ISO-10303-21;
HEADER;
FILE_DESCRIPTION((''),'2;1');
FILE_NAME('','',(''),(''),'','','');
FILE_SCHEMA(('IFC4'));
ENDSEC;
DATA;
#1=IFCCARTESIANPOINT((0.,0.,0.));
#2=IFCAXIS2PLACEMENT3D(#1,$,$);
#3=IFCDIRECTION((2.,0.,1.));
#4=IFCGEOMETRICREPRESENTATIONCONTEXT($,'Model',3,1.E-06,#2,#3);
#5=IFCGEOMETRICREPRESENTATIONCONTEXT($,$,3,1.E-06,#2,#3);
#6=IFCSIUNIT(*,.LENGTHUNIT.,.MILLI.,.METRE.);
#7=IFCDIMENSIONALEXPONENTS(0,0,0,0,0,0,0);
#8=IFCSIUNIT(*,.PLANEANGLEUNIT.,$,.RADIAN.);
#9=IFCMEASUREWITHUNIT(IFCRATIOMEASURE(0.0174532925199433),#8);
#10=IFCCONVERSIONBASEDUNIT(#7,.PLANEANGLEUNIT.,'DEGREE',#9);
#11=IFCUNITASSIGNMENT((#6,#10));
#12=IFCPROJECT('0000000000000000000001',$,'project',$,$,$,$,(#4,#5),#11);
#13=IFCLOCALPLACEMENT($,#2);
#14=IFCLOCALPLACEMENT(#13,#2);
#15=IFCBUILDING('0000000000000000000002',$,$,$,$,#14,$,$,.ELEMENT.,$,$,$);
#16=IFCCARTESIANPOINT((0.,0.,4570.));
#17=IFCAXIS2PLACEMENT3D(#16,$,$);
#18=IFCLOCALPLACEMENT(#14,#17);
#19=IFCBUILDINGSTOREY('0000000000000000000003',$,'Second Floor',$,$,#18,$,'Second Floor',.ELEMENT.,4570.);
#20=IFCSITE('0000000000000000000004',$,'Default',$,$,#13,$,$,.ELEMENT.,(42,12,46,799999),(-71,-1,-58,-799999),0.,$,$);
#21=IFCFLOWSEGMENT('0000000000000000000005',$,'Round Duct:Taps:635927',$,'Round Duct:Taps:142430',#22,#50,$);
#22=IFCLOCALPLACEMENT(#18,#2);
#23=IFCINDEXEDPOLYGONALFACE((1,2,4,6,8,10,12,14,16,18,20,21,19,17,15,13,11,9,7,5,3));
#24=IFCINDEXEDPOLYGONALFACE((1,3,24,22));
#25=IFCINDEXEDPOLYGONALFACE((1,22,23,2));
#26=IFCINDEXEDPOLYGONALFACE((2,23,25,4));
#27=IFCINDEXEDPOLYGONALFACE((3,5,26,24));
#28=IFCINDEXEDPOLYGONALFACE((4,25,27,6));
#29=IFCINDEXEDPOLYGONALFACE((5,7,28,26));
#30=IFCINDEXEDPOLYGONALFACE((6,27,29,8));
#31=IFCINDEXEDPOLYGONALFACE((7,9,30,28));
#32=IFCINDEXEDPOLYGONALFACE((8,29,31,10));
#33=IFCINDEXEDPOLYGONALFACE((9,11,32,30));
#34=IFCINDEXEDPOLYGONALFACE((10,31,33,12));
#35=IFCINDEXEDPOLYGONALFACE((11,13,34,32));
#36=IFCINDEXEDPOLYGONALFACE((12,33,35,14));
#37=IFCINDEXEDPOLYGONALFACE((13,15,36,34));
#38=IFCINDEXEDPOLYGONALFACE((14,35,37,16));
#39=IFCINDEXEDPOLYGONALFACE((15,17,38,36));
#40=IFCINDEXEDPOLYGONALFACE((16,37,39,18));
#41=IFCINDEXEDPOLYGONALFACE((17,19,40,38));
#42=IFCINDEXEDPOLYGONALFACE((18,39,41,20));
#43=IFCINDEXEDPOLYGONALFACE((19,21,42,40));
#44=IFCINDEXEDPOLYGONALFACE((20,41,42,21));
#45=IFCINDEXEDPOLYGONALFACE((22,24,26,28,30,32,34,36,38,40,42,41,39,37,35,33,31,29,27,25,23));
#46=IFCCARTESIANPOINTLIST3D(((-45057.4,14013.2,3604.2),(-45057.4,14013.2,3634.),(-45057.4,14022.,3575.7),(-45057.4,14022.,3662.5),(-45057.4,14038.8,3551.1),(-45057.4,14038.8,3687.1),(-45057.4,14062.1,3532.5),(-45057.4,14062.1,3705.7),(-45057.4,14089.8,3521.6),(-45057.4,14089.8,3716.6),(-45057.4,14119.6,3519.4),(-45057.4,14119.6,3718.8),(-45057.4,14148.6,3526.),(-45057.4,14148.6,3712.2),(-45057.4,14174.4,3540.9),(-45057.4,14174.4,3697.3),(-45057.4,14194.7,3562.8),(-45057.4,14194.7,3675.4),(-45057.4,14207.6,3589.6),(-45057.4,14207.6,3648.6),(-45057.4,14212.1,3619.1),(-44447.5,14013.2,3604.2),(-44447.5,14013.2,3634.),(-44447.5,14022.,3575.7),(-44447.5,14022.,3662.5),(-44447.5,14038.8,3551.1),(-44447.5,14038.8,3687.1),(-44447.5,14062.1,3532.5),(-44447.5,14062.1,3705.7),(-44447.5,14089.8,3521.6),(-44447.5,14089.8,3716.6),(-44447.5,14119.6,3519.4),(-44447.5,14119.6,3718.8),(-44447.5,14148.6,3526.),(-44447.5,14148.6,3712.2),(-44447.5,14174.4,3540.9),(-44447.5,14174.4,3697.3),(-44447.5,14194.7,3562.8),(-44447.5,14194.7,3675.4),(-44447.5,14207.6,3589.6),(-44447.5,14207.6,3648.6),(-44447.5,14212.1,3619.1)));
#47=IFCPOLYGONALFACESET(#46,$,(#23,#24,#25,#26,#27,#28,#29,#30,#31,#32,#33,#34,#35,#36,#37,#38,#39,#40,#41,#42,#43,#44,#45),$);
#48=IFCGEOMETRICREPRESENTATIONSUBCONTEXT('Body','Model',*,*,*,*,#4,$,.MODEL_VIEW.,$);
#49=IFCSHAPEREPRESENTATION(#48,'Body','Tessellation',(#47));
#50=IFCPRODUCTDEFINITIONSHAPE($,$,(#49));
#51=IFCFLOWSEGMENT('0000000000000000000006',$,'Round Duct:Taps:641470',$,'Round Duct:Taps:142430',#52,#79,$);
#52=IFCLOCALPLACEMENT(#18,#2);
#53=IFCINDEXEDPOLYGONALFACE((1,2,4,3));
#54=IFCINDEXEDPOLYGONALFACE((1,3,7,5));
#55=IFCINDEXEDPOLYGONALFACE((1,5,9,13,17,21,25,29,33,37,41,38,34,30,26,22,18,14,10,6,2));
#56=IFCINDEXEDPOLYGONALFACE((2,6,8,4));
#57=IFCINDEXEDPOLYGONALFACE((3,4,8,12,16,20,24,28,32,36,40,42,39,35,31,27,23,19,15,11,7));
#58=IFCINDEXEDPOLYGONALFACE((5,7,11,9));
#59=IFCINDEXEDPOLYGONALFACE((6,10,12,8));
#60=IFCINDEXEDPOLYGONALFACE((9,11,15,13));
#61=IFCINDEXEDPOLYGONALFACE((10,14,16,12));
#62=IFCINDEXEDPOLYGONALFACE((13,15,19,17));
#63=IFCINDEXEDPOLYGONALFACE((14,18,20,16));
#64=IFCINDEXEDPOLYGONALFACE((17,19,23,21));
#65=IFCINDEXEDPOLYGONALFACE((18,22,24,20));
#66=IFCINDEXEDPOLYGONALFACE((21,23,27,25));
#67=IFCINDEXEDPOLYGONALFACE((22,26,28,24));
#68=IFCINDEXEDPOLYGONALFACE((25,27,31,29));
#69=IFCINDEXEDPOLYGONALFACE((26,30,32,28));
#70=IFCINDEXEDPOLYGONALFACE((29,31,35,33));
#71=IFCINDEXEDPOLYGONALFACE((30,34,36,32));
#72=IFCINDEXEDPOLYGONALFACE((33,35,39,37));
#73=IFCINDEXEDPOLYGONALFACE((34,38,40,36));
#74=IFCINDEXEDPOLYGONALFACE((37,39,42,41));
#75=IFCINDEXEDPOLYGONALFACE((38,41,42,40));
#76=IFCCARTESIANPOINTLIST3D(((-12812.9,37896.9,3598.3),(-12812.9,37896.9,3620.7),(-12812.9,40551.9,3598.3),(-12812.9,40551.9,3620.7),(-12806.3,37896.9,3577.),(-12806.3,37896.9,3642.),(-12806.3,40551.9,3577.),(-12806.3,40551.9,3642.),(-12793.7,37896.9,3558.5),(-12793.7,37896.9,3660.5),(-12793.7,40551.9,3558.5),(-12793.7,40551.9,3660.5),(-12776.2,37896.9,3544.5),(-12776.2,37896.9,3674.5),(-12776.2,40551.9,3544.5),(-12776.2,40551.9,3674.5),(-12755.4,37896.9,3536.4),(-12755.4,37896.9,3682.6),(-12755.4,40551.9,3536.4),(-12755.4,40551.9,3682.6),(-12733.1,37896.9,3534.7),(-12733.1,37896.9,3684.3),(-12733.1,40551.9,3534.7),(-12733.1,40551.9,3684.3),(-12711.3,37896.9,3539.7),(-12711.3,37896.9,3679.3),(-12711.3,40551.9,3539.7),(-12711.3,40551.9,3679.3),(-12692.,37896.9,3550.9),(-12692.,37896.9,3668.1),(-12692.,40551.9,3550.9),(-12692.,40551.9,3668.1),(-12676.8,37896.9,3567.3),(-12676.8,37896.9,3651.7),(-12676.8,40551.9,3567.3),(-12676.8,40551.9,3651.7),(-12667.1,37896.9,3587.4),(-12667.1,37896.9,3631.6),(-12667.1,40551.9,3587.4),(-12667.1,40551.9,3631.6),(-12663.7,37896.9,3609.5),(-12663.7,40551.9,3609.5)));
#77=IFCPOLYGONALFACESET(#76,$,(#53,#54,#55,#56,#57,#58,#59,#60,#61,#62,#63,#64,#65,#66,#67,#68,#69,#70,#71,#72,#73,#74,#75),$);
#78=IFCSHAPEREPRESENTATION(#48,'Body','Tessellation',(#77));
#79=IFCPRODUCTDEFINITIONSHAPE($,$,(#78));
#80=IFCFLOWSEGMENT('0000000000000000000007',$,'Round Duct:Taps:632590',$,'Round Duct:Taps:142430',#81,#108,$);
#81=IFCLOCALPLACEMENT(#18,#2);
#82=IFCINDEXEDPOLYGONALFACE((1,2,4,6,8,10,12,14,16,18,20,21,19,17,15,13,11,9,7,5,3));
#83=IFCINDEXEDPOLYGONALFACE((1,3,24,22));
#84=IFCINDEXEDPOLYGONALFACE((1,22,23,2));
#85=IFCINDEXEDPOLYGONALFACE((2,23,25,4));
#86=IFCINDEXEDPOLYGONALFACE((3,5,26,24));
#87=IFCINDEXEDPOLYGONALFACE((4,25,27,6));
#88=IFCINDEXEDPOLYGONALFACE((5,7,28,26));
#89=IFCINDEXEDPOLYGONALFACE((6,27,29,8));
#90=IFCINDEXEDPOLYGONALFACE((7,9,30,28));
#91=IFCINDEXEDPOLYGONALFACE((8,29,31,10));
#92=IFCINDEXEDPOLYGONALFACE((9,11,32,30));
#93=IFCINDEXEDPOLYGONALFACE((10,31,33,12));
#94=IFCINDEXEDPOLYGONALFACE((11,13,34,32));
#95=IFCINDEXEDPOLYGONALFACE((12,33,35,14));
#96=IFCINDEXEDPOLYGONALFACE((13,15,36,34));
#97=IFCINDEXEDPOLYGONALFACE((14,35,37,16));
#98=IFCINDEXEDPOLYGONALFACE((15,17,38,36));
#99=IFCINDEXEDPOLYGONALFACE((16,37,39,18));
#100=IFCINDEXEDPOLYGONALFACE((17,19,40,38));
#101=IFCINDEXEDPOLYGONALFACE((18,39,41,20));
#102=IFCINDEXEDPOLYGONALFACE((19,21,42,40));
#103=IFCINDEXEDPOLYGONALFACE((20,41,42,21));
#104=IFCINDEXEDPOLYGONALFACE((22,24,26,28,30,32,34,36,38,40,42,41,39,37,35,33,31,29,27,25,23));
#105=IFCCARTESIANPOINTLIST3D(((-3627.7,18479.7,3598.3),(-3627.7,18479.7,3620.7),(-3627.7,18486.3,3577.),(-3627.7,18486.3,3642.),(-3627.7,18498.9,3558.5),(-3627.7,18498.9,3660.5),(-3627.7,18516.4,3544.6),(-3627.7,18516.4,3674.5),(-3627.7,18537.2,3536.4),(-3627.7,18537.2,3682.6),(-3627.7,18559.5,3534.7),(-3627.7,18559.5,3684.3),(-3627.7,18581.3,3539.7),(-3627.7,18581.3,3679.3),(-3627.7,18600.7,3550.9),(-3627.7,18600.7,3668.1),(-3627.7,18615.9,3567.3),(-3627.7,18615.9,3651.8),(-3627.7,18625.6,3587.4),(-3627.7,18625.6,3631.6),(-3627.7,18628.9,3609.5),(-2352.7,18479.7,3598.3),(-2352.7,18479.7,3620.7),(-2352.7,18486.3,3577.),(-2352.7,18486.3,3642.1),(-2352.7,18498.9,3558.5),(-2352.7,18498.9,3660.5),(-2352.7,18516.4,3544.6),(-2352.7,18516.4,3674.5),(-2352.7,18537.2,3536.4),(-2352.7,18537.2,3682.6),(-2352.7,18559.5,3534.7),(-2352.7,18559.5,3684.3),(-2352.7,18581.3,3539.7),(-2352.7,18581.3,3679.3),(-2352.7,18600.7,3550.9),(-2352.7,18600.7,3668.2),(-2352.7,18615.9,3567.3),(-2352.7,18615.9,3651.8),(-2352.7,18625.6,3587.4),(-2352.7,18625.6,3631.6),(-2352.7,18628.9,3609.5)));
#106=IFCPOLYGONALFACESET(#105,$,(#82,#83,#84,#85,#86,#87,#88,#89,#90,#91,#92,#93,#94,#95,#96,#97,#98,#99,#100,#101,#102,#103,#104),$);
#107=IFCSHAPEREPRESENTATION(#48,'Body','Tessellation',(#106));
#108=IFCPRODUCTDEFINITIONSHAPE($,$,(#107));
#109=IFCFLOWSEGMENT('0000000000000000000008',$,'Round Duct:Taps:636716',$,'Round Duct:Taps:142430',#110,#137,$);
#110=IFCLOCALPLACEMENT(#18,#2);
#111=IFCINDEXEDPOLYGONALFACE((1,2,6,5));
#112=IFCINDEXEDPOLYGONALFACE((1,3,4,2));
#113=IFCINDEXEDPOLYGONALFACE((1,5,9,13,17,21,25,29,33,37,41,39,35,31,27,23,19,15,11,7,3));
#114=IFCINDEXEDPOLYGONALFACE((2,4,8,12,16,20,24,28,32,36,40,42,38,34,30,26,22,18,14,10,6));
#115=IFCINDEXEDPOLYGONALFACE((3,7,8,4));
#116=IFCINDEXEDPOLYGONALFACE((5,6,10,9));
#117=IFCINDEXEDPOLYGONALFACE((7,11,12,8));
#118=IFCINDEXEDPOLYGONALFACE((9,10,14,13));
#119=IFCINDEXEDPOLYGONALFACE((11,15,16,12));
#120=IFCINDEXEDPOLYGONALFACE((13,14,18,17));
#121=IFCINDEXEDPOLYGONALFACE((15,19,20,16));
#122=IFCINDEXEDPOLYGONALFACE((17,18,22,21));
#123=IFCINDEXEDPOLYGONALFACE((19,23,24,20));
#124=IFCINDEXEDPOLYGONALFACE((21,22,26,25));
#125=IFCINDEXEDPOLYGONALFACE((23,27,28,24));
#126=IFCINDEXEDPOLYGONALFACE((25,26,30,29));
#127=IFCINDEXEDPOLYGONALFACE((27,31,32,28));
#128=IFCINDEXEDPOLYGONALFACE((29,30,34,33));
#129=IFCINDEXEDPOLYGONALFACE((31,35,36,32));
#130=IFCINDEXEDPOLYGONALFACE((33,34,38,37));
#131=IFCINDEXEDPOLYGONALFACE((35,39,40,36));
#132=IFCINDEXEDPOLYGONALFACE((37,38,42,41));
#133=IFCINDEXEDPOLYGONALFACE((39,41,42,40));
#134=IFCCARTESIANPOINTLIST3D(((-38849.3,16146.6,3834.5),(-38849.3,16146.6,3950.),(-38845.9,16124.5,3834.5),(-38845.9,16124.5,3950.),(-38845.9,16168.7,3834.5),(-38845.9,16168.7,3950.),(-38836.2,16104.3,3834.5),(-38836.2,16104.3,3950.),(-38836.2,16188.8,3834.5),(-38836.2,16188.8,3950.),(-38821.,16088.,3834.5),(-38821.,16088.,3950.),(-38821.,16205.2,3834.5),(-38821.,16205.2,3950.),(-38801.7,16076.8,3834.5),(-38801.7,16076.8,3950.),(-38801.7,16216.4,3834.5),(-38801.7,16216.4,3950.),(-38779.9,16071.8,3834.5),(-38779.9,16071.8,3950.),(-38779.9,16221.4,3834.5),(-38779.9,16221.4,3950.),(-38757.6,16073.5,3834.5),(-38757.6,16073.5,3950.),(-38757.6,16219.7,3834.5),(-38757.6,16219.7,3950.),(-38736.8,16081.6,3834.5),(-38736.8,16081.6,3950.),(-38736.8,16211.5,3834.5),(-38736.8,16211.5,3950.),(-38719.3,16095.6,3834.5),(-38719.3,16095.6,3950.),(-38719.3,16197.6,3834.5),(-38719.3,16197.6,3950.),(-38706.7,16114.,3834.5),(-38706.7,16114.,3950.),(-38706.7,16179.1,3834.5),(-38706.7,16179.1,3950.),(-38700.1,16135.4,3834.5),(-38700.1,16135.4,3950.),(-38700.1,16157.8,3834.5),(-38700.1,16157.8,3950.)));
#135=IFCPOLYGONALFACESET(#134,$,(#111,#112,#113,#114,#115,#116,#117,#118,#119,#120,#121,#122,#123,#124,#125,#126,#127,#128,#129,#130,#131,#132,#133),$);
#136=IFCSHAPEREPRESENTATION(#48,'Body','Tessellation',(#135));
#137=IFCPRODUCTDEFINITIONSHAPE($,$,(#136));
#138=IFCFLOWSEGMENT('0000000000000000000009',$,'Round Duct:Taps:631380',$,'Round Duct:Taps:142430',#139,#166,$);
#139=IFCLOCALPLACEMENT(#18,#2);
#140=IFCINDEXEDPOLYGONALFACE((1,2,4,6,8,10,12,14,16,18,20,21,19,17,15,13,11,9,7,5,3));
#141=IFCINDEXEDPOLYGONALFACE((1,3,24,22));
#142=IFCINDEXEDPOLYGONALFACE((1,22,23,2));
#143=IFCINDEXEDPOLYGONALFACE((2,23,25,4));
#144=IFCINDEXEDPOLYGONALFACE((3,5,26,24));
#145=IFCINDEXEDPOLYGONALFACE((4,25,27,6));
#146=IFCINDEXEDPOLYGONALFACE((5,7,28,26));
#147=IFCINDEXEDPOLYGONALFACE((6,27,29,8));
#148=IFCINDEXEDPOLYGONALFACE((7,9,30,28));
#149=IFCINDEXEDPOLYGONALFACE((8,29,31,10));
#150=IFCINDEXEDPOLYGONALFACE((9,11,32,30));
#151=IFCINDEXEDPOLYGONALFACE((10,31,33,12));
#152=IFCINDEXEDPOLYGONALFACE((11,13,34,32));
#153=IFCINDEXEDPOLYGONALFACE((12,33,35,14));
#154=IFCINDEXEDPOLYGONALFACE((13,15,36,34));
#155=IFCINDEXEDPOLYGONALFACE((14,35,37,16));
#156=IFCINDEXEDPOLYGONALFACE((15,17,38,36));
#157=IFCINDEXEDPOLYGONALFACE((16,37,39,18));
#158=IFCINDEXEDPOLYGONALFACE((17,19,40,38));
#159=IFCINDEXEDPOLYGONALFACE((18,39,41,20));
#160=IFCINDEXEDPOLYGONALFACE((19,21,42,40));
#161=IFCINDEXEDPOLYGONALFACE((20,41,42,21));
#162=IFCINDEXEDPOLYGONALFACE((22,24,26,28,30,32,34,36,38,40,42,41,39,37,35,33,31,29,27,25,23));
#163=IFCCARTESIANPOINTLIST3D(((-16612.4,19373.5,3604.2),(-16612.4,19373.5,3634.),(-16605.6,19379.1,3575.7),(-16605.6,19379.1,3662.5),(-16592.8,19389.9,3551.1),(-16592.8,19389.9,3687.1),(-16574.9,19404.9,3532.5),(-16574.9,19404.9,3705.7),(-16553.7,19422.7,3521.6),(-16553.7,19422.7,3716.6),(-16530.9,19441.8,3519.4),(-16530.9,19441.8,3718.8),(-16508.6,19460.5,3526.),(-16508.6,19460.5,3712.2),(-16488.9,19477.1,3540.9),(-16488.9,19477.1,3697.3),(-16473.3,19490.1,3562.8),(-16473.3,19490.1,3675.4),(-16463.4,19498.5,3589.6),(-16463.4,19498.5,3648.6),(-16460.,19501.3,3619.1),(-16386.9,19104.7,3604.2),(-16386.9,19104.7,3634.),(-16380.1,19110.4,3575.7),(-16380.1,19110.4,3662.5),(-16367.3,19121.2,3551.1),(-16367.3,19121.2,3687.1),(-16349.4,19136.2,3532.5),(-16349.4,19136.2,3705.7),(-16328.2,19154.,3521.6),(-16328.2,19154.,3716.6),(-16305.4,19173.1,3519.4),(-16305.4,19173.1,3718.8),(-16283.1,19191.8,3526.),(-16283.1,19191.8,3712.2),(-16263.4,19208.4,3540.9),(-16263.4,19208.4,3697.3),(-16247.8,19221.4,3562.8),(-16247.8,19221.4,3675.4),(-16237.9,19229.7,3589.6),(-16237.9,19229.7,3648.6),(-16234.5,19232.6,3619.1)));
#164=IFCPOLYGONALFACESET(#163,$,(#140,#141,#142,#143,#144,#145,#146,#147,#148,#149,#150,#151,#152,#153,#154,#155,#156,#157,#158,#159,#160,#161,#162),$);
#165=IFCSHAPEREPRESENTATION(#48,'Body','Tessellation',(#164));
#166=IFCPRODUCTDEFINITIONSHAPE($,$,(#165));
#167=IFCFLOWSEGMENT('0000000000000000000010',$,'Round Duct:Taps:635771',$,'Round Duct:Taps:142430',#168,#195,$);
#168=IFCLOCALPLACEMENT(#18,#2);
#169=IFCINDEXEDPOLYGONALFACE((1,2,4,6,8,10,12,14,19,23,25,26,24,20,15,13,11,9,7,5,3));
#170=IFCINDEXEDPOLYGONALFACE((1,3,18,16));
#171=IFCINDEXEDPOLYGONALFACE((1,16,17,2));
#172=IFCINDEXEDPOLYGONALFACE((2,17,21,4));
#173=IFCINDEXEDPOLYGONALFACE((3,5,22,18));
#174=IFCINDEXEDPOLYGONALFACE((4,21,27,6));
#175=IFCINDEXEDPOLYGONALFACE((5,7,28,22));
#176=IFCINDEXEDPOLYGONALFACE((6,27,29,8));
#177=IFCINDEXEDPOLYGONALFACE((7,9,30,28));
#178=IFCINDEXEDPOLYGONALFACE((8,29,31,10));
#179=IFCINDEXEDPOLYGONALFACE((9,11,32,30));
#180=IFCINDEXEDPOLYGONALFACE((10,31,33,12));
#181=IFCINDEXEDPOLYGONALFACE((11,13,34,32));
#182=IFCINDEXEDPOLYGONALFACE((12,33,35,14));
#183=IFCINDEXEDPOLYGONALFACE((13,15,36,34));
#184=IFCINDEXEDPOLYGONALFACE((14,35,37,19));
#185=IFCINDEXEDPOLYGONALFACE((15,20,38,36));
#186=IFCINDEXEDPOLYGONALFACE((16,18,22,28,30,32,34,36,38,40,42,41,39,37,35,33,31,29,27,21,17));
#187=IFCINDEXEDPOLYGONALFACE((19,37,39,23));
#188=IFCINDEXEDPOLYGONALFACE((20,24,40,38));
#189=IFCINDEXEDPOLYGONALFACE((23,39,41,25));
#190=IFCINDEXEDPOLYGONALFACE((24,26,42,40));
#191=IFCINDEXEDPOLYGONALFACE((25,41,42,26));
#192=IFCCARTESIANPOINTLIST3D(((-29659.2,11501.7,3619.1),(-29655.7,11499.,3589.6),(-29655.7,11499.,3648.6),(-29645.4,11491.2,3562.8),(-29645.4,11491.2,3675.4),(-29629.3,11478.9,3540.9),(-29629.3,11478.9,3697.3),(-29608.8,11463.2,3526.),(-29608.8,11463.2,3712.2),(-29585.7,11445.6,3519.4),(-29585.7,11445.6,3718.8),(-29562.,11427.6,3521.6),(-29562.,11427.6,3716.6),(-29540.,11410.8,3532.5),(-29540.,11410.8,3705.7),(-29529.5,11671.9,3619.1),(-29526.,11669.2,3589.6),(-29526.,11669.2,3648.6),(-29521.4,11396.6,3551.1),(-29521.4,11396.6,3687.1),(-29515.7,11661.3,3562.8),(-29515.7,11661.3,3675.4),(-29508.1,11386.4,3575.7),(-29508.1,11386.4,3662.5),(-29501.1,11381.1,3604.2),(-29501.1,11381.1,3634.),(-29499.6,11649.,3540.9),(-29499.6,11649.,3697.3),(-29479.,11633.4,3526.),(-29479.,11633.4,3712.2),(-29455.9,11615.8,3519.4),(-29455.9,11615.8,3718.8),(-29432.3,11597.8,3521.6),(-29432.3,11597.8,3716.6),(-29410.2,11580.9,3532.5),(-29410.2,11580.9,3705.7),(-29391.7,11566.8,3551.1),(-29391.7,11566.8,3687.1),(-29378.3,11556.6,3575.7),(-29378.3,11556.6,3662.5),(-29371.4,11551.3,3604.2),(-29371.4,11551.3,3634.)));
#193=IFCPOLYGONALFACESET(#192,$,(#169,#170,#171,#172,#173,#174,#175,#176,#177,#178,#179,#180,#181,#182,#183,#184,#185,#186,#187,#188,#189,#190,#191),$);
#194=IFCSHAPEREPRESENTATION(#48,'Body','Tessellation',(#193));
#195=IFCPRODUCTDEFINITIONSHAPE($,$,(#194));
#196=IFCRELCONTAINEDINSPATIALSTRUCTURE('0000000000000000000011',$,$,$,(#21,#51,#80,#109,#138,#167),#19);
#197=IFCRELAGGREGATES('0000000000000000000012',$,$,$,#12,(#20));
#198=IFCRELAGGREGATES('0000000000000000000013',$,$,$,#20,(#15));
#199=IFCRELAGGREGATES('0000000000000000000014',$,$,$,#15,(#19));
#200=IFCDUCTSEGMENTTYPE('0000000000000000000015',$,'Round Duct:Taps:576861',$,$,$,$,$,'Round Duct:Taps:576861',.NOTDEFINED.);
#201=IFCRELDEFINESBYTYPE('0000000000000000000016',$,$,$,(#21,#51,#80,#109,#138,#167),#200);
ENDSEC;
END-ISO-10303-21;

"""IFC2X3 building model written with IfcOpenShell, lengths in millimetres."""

from ifc_helpers import new_model, entity, si_unit, converted_unit, direction, frame, frame_2d, origin, origin_2d_with_axis, place, context, subcontext, project, spatial, circle, extrude, type_object, element, save


model = new_model("IFC2X3")

# Units and contexts
model_context = context("Model", 3, precision=1e-06, world=origin(), true_north=direction((2.0, 0.0, 1.0)))
context_of_model = context(None, 3, precision=1e-06, world=origin(), true_north=direction((2.0, 0.0, 1.0)))
body_context = subcontext(model_context, "Body", "Model", "MODEL_VIEW")
ifc_project = project(units=[si_unit("LENGTHUNIT", "METRE", prefix="MILLI"), converted_unit("PLANEANGLEUNIT", "DEGREE", entity("IfcRatioMeasure", 0.0174532925199433), si_unit("PLANEANGLEUNIT", "RADIAN"), dimensions=[0, 0, 0, 0, 0, 0, 0])], contexts=[model_context, context_of_model])

# Site, building, storey
site_placement = place(None, origin())
site = spatial("IfcSite", under=ifc_project, at=site_placement, Name="Default", CompositionType="ELEMENT", RefLatitude=(42, 12, 46, 799999), RefLongitude=(-71, -1, -58, -799999), RefElevation=0.0)
building_placement = place(site_placement, origin())
building = spatial("IfcBuilding", under=site, at=building_placement, CompositionType="ELEMENT")
storey_placement = place(building_placement, frame((0.0, 0.0, 4570.0)))
storey = spatial("IfcBuildingStorey", under=building, at=storey_placement, Name="Second Floor", LongName="Second Floor", CompositionType="ELEMENT", Elevation=4570.0)

# Flow segments
duct_segment_type_1 = type_object("IfcDuctSegmentType", Name="Round Duct:Taps:576861", ElementType="Round Duct:Taps:576861", PredefinedType="NOTDEFINED")
flow_segment_1_placement = place(storey_placement, origin())
element("IfcFlowSegment", 1, at=flow_segment_1_placement, inside=storey, type_object=duct_segment_type_1, Name="Round Duct:Taps:635927", ObjectType="Round Duct:Taps:142430", context=body_context, shape_type="SweptSolid", body=[
    extrude(circle(Radius=100.0, at=frame_2d((0.0, 0.0), x_axis=(1.0, 0.0))), frame((-45057.4, 14112.1, 3619.1), z_axis=(1.0, 0.0, 0.0), x_axis=(0.0, 1.0, 0.0)), (0.0, 0.0, 1.0), 609.9),
])
flow_segment_2_placement = place(storey_placement, origin())
element("IfcFlowSegment", 2, at=flow_segment_2_placement, inside=storey, type_object=duct_segment_type_1, Name="Round Duct:Taps:641470", ObjectType="Round Duct:Taps:142430", context=body_context, shape_type="SweptSolid", body=[
    extrude(circle(Radius=75.0, at=origin_2d_with_axis()), frame((-12738.7, 37896.9, 3609.5), z_axis=(0.0, 1.0, 0.0), x_axis=(1.0, 0.0, 0.0)), (0.0, 0.0, 1.0), 2655.1),
])
flow_segment_3_placement = place(storey_placement, origin())
element("IfcFlowSegment", 3, at=flow_segment_3_placement, inside=storey, type_object=duct_segment_type_1, Name="Round Duct:Taps:632590", ObjectType="Round Duct:Taps:142430", context=body_context, shape_type="SweptSolid", body=[
    extrude(circle(Radius=75.0, at=frame_2d((0.0, 0.0), x_axis=(1.0, 0.0))), frame((-3627.7, 18553.9, 3609.5), z_axis=(1.0, 0.0, 0.000017), x_axis=(0.0, 1.0, 0.0)), (0.0, 0.0, 1.0), 1275.0),
])
flow_segment_4_placement = place(storey_placement, origin())
element("IfcFlowSegment", 4, at=flow_segment_4_placement, inside=storey, type_object=duct_segment_type_1, Name="Round Duct:Taps:636716", ObjectType="Round Duct:Taps:142430", context=body_context, shape_type="SweptSolid", body=[
    extrude(circle(Radius=75.0, at=frame_2d((0.0, 0.0), x_axis=(1.0, 0.0))), frame((-38774.3, 16146.6, 3834.5), z_axis=(0.0, 0.0, 1.0), x_axis=(-1.0, 0.0, 0.0)), (0.0, 0.0, 1.0), 115.5),
])
flow_segment_5_placement = place(storey_placement, origin())
element("IfcFlowSegment", 5, at=flow_segment_5_placement, inside=storey, type_object=duct_segment_type_1, Name="Round Duct:Taps:631380", ObjectType="Round Duct:Taps:142430", context=body_context, shape_type="SweptSolid", body=[
    extrude(circle(Radius=100.0, at=origin_2d_with_axis()), frame((-16536.6, 19437.0, 3619.1), z_axis=(0.642788, -0.766044, 0.0), x_axis=(0.766044, 0.642788, 0.0)), (0.0, 0.0, 1.0), 350.8),
])
flow_segment_6_placement = place(storey_placement, origin())
element("IfcFlowSegment", 6, at=flow_segment_6_placement, inside=storey, type_object=duct_segment_type_1, Name="Round Duct:Taps:635771", ObjectType="Round Duct:Taps:142430", context=body_context, shape_type="SweptSolid", body=[
    extrude(circle(Radius=100.0, at=origin_2d_with_axis()), frame((-29579.7, 11441.1, 3619.1), z_axis=(0.606263, 0.795264, 0.0), x_axis=(-0.795264, 0.606263, 0.0)), (0.0, 0.0, 1.0), 214.0),
])

save(model, "model.ifc")
